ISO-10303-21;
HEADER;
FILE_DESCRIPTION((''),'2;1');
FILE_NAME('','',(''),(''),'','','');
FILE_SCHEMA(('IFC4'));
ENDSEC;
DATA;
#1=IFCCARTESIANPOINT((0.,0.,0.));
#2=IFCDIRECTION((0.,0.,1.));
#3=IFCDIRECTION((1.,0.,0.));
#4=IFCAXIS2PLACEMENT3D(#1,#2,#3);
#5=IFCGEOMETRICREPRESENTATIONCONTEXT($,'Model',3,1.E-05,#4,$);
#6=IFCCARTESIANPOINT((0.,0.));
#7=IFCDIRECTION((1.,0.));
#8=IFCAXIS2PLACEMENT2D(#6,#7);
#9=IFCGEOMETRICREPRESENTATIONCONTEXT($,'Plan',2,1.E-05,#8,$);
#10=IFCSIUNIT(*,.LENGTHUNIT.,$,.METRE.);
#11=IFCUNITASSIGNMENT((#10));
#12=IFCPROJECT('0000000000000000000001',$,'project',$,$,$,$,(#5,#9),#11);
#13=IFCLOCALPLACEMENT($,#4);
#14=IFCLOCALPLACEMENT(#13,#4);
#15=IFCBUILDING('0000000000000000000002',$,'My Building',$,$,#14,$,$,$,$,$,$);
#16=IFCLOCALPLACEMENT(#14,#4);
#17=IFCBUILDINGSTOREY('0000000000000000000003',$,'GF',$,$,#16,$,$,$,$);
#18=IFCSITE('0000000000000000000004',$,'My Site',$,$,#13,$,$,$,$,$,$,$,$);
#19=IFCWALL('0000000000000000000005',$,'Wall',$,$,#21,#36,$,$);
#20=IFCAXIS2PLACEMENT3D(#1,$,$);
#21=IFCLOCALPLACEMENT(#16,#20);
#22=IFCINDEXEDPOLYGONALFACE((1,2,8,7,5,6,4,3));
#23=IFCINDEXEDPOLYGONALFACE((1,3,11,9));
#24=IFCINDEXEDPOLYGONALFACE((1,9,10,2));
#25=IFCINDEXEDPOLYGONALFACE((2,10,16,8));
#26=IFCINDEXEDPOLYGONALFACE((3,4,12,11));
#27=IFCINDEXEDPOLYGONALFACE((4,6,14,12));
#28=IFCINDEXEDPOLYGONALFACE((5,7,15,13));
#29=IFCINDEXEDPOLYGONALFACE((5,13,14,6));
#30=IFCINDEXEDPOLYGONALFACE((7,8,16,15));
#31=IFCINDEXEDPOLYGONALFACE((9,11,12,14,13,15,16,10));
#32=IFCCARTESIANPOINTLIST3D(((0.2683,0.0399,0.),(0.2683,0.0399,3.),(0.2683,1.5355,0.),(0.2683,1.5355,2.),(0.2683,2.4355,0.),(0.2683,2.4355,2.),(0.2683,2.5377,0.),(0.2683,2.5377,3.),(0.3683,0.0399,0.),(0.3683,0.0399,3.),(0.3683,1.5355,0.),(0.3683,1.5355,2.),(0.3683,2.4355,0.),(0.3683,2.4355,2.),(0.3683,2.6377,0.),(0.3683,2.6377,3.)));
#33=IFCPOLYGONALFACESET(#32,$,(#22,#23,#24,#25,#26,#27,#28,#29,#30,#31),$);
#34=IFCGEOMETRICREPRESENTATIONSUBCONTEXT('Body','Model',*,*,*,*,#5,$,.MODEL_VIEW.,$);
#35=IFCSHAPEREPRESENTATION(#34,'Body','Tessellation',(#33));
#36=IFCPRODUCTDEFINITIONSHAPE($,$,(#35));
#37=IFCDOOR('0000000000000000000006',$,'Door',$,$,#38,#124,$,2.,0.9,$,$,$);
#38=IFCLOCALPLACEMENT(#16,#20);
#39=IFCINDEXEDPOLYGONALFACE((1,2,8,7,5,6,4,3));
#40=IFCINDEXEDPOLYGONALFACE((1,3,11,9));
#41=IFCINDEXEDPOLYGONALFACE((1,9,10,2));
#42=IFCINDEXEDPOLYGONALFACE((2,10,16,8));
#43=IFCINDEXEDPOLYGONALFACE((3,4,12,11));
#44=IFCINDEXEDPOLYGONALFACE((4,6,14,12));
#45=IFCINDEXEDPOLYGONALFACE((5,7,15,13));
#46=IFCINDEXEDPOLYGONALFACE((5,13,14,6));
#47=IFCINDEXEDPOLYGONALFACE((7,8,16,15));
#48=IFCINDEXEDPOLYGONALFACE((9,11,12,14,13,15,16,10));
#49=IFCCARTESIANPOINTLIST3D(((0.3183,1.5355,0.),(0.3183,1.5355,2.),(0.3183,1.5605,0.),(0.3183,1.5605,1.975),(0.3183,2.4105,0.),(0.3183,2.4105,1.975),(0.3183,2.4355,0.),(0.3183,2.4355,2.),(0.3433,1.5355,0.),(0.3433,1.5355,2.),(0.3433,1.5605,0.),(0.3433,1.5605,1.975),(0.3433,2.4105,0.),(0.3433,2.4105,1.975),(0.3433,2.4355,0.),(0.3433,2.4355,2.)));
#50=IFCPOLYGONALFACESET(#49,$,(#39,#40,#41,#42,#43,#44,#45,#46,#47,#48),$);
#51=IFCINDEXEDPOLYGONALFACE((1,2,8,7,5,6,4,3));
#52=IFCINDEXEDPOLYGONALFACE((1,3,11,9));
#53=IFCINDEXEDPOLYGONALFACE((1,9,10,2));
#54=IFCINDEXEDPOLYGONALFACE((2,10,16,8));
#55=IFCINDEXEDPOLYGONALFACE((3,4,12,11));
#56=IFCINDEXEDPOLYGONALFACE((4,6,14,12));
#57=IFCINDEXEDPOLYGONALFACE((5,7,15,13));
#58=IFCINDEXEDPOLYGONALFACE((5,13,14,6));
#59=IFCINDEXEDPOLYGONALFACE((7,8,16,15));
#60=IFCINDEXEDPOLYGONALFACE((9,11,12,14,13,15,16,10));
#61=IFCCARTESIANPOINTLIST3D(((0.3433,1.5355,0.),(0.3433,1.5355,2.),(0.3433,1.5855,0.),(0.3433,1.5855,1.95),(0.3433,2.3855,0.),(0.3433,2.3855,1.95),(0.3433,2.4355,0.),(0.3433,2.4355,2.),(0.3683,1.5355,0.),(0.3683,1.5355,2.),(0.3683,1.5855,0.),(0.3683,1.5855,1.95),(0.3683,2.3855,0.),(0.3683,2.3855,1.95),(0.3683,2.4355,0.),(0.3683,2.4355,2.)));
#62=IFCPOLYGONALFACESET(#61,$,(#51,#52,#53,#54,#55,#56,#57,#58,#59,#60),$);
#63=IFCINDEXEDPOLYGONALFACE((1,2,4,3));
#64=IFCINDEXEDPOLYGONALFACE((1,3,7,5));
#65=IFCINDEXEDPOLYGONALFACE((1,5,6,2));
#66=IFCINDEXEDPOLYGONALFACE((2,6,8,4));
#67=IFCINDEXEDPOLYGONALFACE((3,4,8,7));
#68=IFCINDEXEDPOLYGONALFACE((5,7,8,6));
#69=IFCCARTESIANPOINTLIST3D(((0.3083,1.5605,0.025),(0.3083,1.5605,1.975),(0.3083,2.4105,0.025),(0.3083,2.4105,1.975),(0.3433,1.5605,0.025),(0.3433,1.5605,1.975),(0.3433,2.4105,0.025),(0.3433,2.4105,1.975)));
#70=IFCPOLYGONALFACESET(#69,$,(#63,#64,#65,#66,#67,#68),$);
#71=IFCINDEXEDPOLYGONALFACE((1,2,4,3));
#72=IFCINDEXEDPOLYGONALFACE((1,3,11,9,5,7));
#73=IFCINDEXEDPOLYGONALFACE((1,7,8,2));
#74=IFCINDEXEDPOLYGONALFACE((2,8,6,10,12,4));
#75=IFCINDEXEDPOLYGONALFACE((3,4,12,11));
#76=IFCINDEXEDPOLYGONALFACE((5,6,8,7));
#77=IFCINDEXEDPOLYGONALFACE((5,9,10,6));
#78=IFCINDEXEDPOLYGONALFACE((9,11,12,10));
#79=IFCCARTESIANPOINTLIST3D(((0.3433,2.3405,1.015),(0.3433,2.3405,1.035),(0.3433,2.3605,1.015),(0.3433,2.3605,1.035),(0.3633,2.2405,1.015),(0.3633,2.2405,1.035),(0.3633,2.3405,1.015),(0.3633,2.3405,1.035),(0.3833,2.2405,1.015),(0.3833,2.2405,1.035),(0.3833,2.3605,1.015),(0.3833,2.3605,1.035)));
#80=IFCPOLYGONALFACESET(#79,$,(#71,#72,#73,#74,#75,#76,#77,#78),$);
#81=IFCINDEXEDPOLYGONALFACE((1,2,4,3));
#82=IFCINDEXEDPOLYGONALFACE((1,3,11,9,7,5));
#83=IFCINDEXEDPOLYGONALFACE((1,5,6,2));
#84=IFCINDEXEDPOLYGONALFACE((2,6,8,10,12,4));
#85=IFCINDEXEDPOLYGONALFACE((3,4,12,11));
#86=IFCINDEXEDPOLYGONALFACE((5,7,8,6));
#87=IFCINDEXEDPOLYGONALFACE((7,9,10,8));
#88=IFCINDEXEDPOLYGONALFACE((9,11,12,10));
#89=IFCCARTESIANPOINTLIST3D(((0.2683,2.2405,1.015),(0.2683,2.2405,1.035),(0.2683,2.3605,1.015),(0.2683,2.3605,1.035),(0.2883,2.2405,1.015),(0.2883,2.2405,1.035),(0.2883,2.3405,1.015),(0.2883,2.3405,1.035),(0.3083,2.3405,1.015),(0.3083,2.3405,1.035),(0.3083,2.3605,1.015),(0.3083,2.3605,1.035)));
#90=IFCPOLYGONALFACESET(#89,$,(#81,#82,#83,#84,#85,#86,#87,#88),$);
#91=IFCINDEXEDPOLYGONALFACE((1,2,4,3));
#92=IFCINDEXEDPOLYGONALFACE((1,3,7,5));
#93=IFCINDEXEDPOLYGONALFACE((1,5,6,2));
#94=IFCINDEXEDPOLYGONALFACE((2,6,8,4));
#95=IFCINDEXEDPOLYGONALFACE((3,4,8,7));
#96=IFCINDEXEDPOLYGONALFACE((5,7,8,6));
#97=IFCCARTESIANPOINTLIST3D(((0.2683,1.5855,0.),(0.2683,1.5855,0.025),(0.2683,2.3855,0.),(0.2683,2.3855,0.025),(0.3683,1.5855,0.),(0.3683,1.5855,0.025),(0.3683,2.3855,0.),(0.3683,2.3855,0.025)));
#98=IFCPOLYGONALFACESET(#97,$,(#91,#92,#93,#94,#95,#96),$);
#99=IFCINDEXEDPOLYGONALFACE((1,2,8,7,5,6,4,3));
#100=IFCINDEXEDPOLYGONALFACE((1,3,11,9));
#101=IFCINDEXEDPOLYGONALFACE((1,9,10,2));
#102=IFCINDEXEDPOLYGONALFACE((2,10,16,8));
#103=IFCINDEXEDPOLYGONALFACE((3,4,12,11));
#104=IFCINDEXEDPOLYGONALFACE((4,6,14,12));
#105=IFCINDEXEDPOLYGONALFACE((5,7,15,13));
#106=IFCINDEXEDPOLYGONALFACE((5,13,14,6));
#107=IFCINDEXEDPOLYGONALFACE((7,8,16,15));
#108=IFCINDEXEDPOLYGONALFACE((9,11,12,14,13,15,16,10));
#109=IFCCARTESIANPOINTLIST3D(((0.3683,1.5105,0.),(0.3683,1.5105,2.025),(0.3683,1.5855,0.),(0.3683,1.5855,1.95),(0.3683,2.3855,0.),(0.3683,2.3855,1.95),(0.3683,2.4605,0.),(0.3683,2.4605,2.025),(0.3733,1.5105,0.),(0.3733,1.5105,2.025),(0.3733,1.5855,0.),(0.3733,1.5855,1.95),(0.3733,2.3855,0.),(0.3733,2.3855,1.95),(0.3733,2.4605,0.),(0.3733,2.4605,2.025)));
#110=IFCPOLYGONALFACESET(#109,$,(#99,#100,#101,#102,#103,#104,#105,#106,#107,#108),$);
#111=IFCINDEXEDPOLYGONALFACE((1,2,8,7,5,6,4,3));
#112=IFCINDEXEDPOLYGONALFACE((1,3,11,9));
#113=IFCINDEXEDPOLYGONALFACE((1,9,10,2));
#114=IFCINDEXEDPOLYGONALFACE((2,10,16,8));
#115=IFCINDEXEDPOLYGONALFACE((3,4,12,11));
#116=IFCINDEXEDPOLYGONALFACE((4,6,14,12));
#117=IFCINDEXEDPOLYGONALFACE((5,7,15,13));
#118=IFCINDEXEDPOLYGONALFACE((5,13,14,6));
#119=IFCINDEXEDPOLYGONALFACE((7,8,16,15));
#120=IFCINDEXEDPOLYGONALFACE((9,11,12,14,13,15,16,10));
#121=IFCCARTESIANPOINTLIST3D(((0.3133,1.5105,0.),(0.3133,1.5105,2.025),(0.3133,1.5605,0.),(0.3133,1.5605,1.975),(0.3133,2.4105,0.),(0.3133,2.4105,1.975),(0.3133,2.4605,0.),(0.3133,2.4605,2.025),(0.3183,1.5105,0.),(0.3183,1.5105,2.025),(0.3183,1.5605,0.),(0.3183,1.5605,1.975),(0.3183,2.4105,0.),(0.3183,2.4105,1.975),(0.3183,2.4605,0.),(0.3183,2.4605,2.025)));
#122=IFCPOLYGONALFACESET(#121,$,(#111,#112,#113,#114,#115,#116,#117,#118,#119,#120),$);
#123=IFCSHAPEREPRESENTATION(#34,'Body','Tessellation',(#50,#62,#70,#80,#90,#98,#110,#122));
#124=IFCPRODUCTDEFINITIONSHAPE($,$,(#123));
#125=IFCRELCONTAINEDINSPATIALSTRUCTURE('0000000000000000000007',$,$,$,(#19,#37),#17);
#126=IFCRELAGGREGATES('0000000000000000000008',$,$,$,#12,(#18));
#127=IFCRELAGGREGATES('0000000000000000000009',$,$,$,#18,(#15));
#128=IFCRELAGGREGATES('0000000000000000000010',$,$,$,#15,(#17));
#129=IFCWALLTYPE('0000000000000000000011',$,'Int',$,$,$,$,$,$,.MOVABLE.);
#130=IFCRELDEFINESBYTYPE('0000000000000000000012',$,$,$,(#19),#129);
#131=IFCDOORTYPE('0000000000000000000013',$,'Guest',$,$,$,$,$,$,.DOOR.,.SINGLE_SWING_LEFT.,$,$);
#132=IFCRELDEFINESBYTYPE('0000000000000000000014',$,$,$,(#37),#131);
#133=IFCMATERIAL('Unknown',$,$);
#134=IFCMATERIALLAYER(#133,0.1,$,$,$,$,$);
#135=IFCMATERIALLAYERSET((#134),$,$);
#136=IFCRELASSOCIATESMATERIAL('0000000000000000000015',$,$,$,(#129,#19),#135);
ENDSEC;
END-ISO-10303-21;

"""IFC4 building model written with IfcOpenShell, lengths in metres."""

from ifc_helpers import new_model, entity, si_unit, frame, origin_with_axes, origin_2d_with_axis, place, context, subcontext, project, spatial, line, indexed_curve, outline, extrude, shape, source, transform, mapped, material, layer, layer_set, layer_usage, type_object, type_shapes, element, fill, save


model = new_model("IFC4")

# Units and contexts
model_context = context("Model", 3, precision=1e-05, world=origin_with_axes())
plan_context = context("Plan", 2, precision=1e-05, world=origin_2d_with_axis())
body_context_1 = subcontext(model_context, "Body", "Model", "MODEL_VIEW")
body_context_2 = subcontext(plan_context, "Body", "Plan", "PLAN_VIEW")
ifc_project = project(units=[si_unit("LENGTHUNIT", "METRE")], contexts=[model_context, plan_context])

# Site, building, storey
site_placement = place(None, origin_with_axes())
site = spatial("IfcSite", under=ifc_project, at=site_placement, Name="My Site")
building_placement = place(site_placement, origin_with_axes())
building = spatial("IfcBuilding", under=site, at=building_placement, Name="My Building")
storey_placement = place(building_placement, origin_with_axes())
storey = spatial("IfcBuildingStorey", under=building, at=storey_placement, Name="GF")

# Shared definitions
ifc_material = material(Name="Unknown")

# Shared definitions
ifc_layer_1 = layer(ifc_material, 0.1)
ifc_layer_set_1 = layer_set([ifc_layer_1])
wall_type_1 = type_object("IfcWallType", Name="Int", PredefinedType="MOVABLE", material=ifc_layer_set_1)

# Wall, opening, door
ifc_layer_usage_1 = layer_usage(ifc_layer_set_1, "AXIS2", "POSITIVE", 0.0)
wall_1_placement = place(storey_placement, frame((0.2683, 2.5377, 0.0), z_axis=(0.0, 0.0, 1.0), x_axis=(0.0, -1.0, 0.0)))
wall_1 = element("IfcWall", 1, at=wall_1_placement, inside=storey, type_object=wall_type_1, material=ifc_layer_usage_1, Name="Wall", context=body_context_1, shape_type="SweptSolid", body=[
    extrude(outline(indexed_curve([(0.0, 0.0), (-0.1, 0.1), (2.4978, 0.1), (2.4978, 0.0)], segments=[line(1, 2, 3, 4, 1)])), origin_with_axes(), (0.0, 0.0, 1.0), 3.0),
])
shared_shape_1 = source(origin_with_axes(), body_context_1, "Body", "SweptSolid", [
    extrude(outline(indexed_curve([(0.0, 0.0), (0.9, 0.0), (0.9, 2.0), (0.0, 2.0)], segments=[line(1, 2, 3, 4, 1)])), frame((0.0, -0.6, 0.0), z_axis=(0.0, -1.0, 0.0), x_axis=(1.0, 0.0, 0.0)), (0.0, 0.0, -1.0), 1.2),
])
opening_1_placement = place(wall_1_placement, frame((1.0022, 0.1, 0.0), z_axis=(0.0, 0.0, 1.0), x_axis=(-1.0, 0.0, 0.0)))
opening_1 = element("IfcOpeningElement", 2, at=opening_1_placement, cuts=wall_1, PredefinedType="OPENING", context=body_context_1, shape_type="MappedRepresentation", body=[
    mapped(shared_shape_1, transform((0.0, 0.0, 0.0), x_axis=(1.0, 0.0, 0.0), y_axis=(0.0, 1.0, 0.0), z_axis=(0.0, 0.0, 1.0), scale=1.0)),
])
door_type_1 = type_object("IfcDoorType", Name="Guest", OperationType="SINGLE_SWING_LEFT", PredefinedType="DOOR")
shared_shape_2 = source(origin_with_axes(), body_context_1, "Body", "SweptSolid", [
    extrude(outline(indexed_curve([(0.0, 0.0), (0.0, 2.0), (0.9, 2.0), (0.9, 0.0), (0.875, 0.0), (0.875, 1.975), (0.025, 1.975), (0.025, 0.0)], segments=[line(1, 2, 3, 4, 5, 6, 7, 8, 1)])), frame((0.0, 0.025, 0.0), z_axis=(0.0, -1.0, 0.0), x_axis=(1.0, 0.0, 0.0)), (0.0, 0.0, -1.0), 0.025),
    extrude(outline(indexed_curve([(0.0, 0.0), (0.0, 2.0), (0.9, 2.0), (0.9, 0.0), (0.85, 0.0), (0.85, 1.95), (0.05, 1.95), (0.05, 0.0)], segments=[line(1, 2, 3, 4, 5, 6, 7, 8, 1)])), frame((0.0, 0.0, 0.0), z_axis=(0.0, -1.0, 0.0), x_axis=(1.0, 0.0, 0.0)), (0.0, 0.0, -1.0), 0.025),
    extrude(outline(indexed_curve([(0.0, 0.0), (0.85, 0.0), (0.85, 0.035), (0.0, 0.035)], segments=[line(1, 2, 3, 4, 1)])), frame((0.025, 0.025, 0.025), z_axis=(0.0, 0.0, 1.0), x_axis=(1.0, 0.0, 0.0)), (0.0, 0.0, 1.0), 1.95),
    extrude(outline(indexed_curve([(0.0, 0.0), (0.0, -0.04), (-0.12, -0.04), (-0.12, -0.02), (-0.02, -0.02), (-0.02, 0.0)], segments=[line(1, 2, 3, 4, 5, 6, 1)])), frame((0.825, 0.025, 1.015), z_axis=(0.0, 0.0, 1.0), x_axis=(1.0, 0.0, 0.0)), (0.0, 0.0, 1.0), 0.02),
    extrude(outline(indexed_curve([(0.0, 0.0), (0.0, 0.04), (-0.12, 0.04), (-0.12, 0.02), (-0.02, 0.02), (-0.02, 0.0)], segments=[line(1, 2, 3, 4, 5, 6, 1)])), frame((0.825, 0.06, 1.015), z_axis=(0.0, 0.0, 1.0), x_axis=(1.0, 0.0, 0.0)), (0.0, 0.0, 1.0), 0.02),
    extrude(outline(indexed_curve([(0.0, 0.1), (0.8, 0.1), (0.8, 0.0), (0.0, 0.0), (0.0, 0.1)])), frame((0.05, 0.0, 0.0), z_axis=(0.0, 0.0, 1.0), x_axis=(1.0, 0.0, 0.0)), (0.0, 0.0, 1.0), 0.025),
    extrude(outline(indexed_curve([(0.0, 0.0), (0.0, 2.025), (0.95, 2.025), (0.95, 0.0), (0.875, 0.0), (0.875, 1.95), (0.075, 1.95), (0.075, 0.0)], segments=[line(1, 2, 3, 4, 5, 6, 7, 8, 1)])), frame((-0.025, -0.005, 0.0), z_axis=(0.0, -1.0, 0.0), x_axis=(1.0, 0.0, 0.0)), (0.0, 0.0, -1.0), 0.005),
    extrude(outline(indexed_curve([(0.0, 0.0), (0.0, 2.025), (0.95, 2.025), (0.95, 0.0), (0.9, 0.0), (0.9, 1.975), (0.05, 1.975), (0.05, 0.0)], segments=[line(1, 2, 3, 4, 5, 6, 7, 8, 1)])), frame((-0.025, 0.05, 0.0), z_axis=(0.0, -1.0, 0.0), x_axis=(1.0, 0.0, 0.0)), (0.0, 0.0, -1.0), 0.005),
])
shared_shape_3 = source(origin_with_axes(), body_context_2, "Body", "Curve2D", [
    entity("IfcIndexedPolyCurve", entity("IfcCartesianPointList2D", [[0.0, 0.0], [0.0, 0.05], [0.025, 0.05], [0.025, 0.025], [0.05, 0.025], [0.05, 0.0]]), [entity("IfcLineIndex", [1, 2, 3, 4, 5, 6, 1])]),
    entity("IfcIndexedPolyCurve", entity("IfcCartesianPointList2D", [[0.9, 0.0], [0.9, 0.05], [0.875, 0.05], [0.875, 0.025], [0.85, 0.025], [0.85, 0.0]]), [entity("IfcLineIndex", [1, 2, 3, 4, 5, 6, 1])]),
    entity("IfcTrimmedCurve", entity("IfcEllipse", entity("IfcAxis2Placement2D", entity("IfcCartesianPoint", [0.06, 0.05]), entity("IfcDirection", [1.0, 0.0])), 0.815, 0.85), [entity("IfcCartesianPoint", [0.875, 0.05])], [entity("IfcCartesianPoint", [0.06, 0.9])], True, "CARTESIAN"),
    entity("IfcIndexedPolyCurve", entity("IfcCartesianPointList2D", [[0.025, 0.05], [0.06, 0.05], [0.06, 0.9], [0.025, 0.9]]), [entity("IfcLineIndex", [1, 2, 3, 4, 1])]),
])
type_shapes(door_type_1, [shared_shape_2, shared_shape_3])
door_1_placement = place(opening_1_placement, frame((0.0, 0.0, 0.0), z_axis=(0.0, 0.0, 1.0), x_axis=(1.0, 0.0, 0.0)))
door_1 = element("IfcDoor", 3, at=door_1_placement, inside=storey, type_object=door_type_1, Name="Door", OverallHeight=2.0, OverallWidth=0.9, shapes=[
    shape(body_context_1, "Body", "MappedRepresentation", [mapped(shared_shape_2, transform((0.0, 0.0, 0.0), x_axis=(1.0, 0.0, 0.0), y_axis=(0.0, 1.0, 0.0), z_axis=(0.0, 0.0, 1.0), scale=1.0))]),
    shape(body_context_2, "Body", "MappedRepresentation", [mapped(shared_shape_3, transform((0.0, 0.0, 0.0), x_axis=(1.0, 0.0, 0.0), y_axis=(0.0, 1.0, 0.0), z_axis=(0.0, 0.0, 1.0), scale=1.0))]),
])
fill(opening_1, door_1)

save(model, "model.ifc")
